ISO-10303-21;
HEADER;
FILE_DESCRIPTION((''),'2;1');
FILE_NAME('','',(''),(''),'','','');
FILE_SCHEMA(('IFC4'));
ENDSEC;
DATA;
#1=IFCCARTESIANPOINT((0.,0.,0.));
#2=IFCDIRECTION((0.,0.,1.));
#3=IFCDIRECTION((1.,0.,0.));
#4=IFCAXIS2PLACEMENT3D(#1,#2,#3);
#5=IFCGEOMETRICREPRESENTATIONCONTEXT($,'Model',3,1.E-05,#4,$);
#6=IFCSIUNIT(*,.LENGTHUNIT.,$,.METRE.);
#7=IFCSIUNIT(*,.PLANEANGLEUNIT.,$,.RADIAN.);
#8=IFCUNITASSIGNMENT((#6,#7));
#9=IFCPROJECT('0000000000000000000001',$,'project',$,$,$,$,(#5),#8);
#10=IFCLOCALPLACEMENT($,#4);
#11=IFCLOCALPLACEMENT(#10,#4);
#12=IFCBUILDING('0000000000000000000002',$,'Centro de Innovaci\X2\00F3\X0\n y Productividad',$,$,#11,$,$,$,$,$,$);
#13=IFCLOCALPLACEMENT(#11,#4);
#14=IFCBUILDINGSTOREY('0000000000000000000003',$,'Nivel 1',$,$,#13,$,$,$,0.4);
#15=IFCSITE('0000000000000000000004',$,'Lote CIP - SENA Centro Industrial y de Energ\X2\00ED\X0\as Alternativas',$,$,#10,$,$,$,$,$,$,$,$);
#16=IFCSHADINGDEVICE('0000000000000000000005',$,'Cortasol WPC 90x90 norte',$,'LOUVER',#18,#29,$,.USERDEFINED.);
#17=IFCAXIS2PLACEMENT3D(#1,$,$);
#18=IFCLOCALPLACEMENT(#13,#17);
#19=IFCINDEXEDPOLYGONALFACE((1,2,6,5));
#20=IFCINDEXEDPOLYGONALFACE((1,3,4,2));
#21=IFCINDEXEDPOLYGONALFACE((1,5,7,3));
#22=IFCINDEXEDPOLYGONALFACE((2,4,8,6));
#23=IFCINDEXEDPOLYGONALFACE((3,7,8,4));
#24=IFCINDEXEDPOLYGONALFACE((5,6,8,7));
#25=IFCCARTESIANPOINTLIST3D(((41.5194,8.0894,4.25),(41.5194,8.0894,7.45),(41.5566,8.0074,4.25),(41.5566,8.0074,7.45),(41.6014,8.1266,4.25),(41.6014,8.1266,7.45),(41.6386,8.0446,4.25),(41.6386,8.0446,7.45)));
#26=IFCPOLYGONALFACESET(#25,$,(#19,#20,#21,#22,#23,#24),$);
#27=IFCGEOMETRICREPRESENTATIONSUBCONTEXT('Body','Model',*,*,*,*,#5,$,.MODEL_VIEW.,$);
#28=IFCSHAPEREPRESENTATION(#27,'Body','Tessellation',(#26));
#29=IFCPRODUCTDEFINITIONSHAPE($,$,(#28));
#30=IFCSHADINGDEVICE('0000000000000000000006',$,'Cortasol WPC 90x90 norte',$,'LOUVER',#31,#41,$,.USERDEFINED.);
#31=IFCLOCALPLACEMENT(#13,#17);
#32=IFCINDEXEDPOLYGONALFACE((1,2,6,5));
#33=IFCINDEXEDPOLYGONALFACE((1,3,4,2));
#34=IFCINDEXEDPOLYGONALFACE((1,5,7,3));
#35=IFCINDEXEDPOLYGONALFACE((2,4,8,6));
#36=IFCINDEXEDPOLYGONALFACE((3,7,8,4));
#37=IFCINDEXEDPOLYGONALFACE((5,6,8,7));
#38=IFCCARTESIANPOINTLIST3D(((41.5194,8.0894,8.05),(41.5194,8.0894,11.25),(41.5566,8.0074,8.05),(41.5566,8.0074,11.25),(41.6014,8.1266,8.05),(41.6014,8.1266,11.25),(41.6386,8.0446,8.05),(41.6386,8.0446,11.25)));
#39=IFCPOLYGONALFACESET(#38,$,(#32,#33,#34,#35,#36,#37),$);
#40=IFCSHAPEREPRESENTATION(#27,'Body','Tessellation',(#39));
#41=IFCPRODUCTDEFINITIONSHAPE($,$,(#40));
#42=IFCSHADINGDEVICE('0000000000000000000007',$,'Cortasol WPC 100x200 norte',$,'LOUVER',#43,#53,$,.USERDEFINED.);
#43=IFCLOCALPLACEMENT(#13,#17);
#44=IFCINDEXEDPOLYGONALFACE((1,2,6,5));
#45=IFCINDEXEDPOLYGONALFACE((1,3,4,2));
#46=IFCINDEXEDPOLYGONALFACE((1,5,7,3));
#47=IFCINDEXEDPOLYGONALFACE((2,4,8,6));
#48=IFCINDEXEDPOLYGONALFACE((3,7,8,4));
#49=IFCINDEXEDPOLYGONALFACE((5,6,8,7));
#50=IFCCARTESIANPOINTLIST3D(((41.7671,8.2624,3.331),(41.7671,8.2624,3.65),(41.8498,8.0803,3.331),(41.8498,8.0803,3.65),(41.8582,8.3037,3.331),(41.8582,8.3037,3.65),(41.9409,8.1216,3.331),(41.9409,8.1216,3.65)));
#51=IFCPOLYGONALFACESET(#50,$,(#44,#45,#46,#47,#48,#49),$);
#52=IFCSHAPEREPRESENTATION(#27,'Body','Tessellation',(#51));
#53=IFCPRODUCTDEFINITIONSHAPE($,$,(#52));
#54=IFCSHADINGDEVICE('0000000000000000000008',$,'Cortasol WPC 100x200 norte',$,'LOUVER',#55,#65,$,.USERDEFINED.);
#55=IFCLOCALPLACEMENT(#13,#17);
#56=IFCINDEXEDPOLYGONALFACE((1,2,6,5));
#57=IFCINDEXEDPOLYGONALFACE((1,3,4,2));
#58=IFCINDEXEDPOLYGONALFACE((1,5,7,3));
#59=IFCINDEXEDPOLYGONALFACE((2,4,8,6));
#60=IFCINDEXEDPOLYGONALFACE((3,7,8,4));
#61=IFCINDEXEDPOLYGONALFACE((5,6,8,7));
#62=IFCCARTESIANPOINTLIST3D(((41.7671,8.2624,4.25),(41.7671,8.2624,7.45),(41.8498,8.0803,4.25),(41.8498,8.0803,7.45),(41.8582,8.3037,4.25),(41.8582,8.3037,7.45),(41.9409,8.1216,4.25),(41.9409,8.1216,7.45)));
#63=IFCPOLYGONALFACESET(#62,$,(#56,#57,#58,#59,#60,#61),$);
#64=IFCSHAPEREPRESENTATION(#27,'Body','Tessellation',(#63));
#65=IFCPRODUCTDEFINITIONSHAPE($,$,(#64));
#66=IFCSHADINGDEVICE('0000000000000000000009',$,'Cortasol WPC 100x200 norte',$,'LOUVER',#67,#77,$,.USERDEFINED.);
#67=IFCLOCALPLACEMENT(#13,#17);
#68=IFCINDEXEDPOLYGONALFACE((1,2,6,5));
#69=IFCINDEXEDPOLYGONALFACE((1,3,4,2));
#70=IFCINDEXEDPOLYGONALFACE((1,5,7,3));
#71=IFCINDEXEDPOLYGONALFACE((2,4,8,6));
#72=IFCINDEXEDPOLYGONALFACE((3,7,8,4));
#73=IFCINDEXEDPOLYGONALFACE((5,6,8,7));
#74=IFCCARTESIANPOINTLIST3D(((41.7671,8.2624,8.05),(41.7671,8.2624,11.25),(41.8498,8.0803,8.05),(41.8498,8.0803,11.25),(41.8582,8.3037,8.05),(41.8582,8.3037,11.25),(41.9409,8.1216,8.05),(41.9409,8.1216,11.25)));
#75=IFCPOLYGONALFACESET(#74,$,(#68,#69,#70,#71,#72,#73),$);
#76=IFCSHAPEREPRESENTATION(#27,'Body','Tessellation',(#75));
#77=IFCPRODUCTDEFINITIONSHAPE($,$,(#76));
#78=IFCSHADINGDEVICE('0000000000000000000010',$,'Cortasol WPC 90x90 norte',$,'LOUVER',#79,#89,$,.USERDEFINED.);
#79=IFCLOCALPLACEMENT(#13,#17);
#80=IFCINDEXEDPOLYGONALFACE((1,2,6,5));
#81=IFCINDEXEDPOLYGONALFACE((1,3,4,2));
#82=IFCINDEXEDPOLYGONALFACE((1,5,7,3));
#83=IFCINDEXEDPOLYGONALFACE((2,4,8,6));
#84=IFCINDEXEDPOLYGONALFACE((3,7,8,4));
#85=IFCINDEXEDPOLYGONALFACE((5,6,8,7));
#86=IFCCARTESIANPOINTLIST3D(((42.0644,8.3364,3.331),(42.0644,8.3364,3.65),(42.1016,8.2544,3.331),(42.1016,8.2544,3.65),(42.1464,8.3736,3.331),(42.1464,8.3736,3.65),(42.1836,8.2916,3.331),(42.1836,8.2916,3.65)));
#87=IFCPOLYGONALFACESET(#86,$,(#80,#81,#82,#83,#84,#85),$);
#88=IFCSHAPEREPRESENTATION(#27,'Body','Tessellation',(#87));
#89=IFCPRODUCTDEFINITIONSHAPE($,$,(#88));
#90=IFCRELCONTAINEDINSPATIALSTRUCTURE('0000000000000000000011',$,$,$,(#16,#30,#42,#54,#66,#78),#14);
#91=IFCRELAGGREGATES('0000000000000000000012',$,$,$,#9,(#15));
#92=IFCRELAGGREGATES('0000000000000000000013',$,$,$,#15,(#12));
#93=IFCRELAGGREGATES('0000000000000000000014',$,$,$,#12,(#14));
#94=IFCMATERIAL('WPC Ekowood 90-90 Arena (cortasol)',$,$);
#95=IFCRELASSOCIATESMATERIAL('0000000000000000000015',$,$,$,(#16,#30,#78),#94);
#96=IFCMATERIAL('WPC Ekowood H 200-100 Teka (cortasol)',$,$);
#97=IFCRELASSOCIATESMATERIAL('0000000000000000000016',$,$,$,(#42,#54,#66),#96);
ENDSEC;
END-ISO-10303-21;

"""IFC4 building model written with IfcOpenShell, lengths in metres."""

from ifc_helpers import new_model, si_unit, frame, origin_with_axes, place, context, subcontext, project, spatial, polyline, outline, extrude, material, element, save


model = new_model("IFC4")

# Units and contexts
model_context = context("Model", 3, precision=1e-05, world=origin_with_axes())
body_context = subcontext(model_context, "Body", "Model", "MODEL_VIEW")
ifc_project = project(units=[si_unit("LENGTHUNIT", "METRE"), si_unit("PLANEANGLEUNIT", "RADIAN")], contexts=[model_context])

# Site, building, storey
site_placement = place(None, origin_with_axes())
site = spatial("IfcSite", under=ifc_project, at=site_placement, Name="Lote CIP - SENA Centro Industrial y de Energías Alternativas")
building_placement = place(site_placement, origin_with_axes())
building = spatial("IfcBuilding", under=site, at=building_placement, Name="Centro de Innovación y Productividad")
storey_placement = place(building_placement, origin_with_axes())
storey = spatial("IfcBuildingStorey", under=building, at=storey_placement, Name="Nivel 1", Elevation=0.4)

# Shading devices
ifc_material_1 = material(Name="WPC Ekowood H 200-100 Teka (cortasol)")
ifc_material_2 = material(Name="WPC Ekowood 90-90 Arena (cortasol)")
shading_device_1_placement = place(storey_placement, origin_with_axes())
element("IfcShadingDevice", 1, at=shading_device_1_placement, inside=storey, material=ifc_material_2, Name="Cortasol WPC 90x90 norte", ObjectType="LOUVER", PredefinedType="USERDEFINED", context=body_context, shape_type="SweptSolid", body=[
    extrude(outline(polyline([(41.5566, 8.0074), (41.5194, 8.0894), (41.6014, 8.1266), (41.6386, 8.0446), (41.5566, 8.0074)])), frame((0.0, 0.0, 4.25)), (0.0, 0.0, 1.0), 3.2),
])
shading_device_2_placement = place(storey_placement, origin_with_axes())
element("IfcShadingDevice", 2, at=shading_device_2_placement, inside=storey, material=ifc_material_2, Name="Cortasol WPC 90x90 norte", ObjectType="LOUVER", PredefinedType="USERDEFINED", context=body_context, shape_type="SweptSolid", body=[
    extrude(outline(polyline([(41.5566, 8.0074), (41.5194, 8.0894), (41.6014, 8.1266), (41.6386, 8.0446), (41.5566, 8.0074)])), frame((0.0, 0.0, 8.05)), (0.0, 0.0, 1.0), 3.2),
])
shading_device_3_placement = place(storey_placement, origin_with_axes())
element("IfcShadingDevice", 3, at=shading_device_3_placement, inside=storey, material=ifc_material_1, Name="Cortasol WPC 100x200 norte", ObjectType="LOUVER", PredefinedType="USERDEFINED", context=body_context, shape_type="SweptSolid", body=[
    extrude(outline(polyline([(41.8498, 8.0803), (41.7671, 8.2624), (41.8582, 8.3037), (41.9409, 8.1216), (41.8498, 8.0803)])), frame((0.0, 0.0, 3.331)), (0.0, 0.0, 1.0), 0.319),
])
shading_device_4_placement = place(storey_placement, origin_with_axes())
element("IfcShadingDevice", 4, at=shading_device_4_placement, inside=storey, material=ifc_material_1, Name="Cortasol WPC 100x200 norte", ObjectType="LOUVER", PredefinedType="USERDEFINED", context=body_context, shape_type="SweptSolid", body=[
    extrude(outline(polyline([(41.8498, 8.0803), (41.7671, 8.2624), (41.8582, 8.3037), (41.9409, 8.1216), (41.8498, 8.0803)])), frame((0.0, 0.0, 4.25)), (0.0, 0.0, 1.0), 3.2),
])
shading_device_5_placement = place(storey_placement, origin_with_axes())
element("IfcShadingDevice", 5, at=shading_device_5_placement, inside=storey, material=ifc_material_1, Name="Cortasol WPC 100x200 norte", ObjectType="LOUVER", PredefinedType="USERDEFINED", context=body_context, shape_type="SweptSolid", body=[
    extrude(outline(polyline([(41.8498, 8.0803), (41.7671, 8.2624), (41.8582, 8.3037), (41.9409, 8.1216), (41.8498, 8.0803)])), frame((0.0, 0.0, 8.05)), (0.0, 0.0, 1.0), 3.2),
])
shading_device_6_placement = place(storey_placement, origin_with_axes())
element("IfcShadingDevice", 6, at=shading_device_6_placement, inside=storey, material=ifc_material_2, Name="Cortasol WPC 90x90 norte", ObjectType="LOUVER", PredefinedType="USERDEFINED", context=body_context, shape_type="SweptSolid", body=[
    extrude(outline(polyline([(42.1016, 8.2544), (42.0644, 8.3364), (42.1464, 8.3736), (42.1836, 8.2916), (42.1016, 8.2544)])), frame((0.0, 0.0, 3.331)), (0.0, 0.0, 1.0), 0.319),
])

save(model, "model.ifc")
